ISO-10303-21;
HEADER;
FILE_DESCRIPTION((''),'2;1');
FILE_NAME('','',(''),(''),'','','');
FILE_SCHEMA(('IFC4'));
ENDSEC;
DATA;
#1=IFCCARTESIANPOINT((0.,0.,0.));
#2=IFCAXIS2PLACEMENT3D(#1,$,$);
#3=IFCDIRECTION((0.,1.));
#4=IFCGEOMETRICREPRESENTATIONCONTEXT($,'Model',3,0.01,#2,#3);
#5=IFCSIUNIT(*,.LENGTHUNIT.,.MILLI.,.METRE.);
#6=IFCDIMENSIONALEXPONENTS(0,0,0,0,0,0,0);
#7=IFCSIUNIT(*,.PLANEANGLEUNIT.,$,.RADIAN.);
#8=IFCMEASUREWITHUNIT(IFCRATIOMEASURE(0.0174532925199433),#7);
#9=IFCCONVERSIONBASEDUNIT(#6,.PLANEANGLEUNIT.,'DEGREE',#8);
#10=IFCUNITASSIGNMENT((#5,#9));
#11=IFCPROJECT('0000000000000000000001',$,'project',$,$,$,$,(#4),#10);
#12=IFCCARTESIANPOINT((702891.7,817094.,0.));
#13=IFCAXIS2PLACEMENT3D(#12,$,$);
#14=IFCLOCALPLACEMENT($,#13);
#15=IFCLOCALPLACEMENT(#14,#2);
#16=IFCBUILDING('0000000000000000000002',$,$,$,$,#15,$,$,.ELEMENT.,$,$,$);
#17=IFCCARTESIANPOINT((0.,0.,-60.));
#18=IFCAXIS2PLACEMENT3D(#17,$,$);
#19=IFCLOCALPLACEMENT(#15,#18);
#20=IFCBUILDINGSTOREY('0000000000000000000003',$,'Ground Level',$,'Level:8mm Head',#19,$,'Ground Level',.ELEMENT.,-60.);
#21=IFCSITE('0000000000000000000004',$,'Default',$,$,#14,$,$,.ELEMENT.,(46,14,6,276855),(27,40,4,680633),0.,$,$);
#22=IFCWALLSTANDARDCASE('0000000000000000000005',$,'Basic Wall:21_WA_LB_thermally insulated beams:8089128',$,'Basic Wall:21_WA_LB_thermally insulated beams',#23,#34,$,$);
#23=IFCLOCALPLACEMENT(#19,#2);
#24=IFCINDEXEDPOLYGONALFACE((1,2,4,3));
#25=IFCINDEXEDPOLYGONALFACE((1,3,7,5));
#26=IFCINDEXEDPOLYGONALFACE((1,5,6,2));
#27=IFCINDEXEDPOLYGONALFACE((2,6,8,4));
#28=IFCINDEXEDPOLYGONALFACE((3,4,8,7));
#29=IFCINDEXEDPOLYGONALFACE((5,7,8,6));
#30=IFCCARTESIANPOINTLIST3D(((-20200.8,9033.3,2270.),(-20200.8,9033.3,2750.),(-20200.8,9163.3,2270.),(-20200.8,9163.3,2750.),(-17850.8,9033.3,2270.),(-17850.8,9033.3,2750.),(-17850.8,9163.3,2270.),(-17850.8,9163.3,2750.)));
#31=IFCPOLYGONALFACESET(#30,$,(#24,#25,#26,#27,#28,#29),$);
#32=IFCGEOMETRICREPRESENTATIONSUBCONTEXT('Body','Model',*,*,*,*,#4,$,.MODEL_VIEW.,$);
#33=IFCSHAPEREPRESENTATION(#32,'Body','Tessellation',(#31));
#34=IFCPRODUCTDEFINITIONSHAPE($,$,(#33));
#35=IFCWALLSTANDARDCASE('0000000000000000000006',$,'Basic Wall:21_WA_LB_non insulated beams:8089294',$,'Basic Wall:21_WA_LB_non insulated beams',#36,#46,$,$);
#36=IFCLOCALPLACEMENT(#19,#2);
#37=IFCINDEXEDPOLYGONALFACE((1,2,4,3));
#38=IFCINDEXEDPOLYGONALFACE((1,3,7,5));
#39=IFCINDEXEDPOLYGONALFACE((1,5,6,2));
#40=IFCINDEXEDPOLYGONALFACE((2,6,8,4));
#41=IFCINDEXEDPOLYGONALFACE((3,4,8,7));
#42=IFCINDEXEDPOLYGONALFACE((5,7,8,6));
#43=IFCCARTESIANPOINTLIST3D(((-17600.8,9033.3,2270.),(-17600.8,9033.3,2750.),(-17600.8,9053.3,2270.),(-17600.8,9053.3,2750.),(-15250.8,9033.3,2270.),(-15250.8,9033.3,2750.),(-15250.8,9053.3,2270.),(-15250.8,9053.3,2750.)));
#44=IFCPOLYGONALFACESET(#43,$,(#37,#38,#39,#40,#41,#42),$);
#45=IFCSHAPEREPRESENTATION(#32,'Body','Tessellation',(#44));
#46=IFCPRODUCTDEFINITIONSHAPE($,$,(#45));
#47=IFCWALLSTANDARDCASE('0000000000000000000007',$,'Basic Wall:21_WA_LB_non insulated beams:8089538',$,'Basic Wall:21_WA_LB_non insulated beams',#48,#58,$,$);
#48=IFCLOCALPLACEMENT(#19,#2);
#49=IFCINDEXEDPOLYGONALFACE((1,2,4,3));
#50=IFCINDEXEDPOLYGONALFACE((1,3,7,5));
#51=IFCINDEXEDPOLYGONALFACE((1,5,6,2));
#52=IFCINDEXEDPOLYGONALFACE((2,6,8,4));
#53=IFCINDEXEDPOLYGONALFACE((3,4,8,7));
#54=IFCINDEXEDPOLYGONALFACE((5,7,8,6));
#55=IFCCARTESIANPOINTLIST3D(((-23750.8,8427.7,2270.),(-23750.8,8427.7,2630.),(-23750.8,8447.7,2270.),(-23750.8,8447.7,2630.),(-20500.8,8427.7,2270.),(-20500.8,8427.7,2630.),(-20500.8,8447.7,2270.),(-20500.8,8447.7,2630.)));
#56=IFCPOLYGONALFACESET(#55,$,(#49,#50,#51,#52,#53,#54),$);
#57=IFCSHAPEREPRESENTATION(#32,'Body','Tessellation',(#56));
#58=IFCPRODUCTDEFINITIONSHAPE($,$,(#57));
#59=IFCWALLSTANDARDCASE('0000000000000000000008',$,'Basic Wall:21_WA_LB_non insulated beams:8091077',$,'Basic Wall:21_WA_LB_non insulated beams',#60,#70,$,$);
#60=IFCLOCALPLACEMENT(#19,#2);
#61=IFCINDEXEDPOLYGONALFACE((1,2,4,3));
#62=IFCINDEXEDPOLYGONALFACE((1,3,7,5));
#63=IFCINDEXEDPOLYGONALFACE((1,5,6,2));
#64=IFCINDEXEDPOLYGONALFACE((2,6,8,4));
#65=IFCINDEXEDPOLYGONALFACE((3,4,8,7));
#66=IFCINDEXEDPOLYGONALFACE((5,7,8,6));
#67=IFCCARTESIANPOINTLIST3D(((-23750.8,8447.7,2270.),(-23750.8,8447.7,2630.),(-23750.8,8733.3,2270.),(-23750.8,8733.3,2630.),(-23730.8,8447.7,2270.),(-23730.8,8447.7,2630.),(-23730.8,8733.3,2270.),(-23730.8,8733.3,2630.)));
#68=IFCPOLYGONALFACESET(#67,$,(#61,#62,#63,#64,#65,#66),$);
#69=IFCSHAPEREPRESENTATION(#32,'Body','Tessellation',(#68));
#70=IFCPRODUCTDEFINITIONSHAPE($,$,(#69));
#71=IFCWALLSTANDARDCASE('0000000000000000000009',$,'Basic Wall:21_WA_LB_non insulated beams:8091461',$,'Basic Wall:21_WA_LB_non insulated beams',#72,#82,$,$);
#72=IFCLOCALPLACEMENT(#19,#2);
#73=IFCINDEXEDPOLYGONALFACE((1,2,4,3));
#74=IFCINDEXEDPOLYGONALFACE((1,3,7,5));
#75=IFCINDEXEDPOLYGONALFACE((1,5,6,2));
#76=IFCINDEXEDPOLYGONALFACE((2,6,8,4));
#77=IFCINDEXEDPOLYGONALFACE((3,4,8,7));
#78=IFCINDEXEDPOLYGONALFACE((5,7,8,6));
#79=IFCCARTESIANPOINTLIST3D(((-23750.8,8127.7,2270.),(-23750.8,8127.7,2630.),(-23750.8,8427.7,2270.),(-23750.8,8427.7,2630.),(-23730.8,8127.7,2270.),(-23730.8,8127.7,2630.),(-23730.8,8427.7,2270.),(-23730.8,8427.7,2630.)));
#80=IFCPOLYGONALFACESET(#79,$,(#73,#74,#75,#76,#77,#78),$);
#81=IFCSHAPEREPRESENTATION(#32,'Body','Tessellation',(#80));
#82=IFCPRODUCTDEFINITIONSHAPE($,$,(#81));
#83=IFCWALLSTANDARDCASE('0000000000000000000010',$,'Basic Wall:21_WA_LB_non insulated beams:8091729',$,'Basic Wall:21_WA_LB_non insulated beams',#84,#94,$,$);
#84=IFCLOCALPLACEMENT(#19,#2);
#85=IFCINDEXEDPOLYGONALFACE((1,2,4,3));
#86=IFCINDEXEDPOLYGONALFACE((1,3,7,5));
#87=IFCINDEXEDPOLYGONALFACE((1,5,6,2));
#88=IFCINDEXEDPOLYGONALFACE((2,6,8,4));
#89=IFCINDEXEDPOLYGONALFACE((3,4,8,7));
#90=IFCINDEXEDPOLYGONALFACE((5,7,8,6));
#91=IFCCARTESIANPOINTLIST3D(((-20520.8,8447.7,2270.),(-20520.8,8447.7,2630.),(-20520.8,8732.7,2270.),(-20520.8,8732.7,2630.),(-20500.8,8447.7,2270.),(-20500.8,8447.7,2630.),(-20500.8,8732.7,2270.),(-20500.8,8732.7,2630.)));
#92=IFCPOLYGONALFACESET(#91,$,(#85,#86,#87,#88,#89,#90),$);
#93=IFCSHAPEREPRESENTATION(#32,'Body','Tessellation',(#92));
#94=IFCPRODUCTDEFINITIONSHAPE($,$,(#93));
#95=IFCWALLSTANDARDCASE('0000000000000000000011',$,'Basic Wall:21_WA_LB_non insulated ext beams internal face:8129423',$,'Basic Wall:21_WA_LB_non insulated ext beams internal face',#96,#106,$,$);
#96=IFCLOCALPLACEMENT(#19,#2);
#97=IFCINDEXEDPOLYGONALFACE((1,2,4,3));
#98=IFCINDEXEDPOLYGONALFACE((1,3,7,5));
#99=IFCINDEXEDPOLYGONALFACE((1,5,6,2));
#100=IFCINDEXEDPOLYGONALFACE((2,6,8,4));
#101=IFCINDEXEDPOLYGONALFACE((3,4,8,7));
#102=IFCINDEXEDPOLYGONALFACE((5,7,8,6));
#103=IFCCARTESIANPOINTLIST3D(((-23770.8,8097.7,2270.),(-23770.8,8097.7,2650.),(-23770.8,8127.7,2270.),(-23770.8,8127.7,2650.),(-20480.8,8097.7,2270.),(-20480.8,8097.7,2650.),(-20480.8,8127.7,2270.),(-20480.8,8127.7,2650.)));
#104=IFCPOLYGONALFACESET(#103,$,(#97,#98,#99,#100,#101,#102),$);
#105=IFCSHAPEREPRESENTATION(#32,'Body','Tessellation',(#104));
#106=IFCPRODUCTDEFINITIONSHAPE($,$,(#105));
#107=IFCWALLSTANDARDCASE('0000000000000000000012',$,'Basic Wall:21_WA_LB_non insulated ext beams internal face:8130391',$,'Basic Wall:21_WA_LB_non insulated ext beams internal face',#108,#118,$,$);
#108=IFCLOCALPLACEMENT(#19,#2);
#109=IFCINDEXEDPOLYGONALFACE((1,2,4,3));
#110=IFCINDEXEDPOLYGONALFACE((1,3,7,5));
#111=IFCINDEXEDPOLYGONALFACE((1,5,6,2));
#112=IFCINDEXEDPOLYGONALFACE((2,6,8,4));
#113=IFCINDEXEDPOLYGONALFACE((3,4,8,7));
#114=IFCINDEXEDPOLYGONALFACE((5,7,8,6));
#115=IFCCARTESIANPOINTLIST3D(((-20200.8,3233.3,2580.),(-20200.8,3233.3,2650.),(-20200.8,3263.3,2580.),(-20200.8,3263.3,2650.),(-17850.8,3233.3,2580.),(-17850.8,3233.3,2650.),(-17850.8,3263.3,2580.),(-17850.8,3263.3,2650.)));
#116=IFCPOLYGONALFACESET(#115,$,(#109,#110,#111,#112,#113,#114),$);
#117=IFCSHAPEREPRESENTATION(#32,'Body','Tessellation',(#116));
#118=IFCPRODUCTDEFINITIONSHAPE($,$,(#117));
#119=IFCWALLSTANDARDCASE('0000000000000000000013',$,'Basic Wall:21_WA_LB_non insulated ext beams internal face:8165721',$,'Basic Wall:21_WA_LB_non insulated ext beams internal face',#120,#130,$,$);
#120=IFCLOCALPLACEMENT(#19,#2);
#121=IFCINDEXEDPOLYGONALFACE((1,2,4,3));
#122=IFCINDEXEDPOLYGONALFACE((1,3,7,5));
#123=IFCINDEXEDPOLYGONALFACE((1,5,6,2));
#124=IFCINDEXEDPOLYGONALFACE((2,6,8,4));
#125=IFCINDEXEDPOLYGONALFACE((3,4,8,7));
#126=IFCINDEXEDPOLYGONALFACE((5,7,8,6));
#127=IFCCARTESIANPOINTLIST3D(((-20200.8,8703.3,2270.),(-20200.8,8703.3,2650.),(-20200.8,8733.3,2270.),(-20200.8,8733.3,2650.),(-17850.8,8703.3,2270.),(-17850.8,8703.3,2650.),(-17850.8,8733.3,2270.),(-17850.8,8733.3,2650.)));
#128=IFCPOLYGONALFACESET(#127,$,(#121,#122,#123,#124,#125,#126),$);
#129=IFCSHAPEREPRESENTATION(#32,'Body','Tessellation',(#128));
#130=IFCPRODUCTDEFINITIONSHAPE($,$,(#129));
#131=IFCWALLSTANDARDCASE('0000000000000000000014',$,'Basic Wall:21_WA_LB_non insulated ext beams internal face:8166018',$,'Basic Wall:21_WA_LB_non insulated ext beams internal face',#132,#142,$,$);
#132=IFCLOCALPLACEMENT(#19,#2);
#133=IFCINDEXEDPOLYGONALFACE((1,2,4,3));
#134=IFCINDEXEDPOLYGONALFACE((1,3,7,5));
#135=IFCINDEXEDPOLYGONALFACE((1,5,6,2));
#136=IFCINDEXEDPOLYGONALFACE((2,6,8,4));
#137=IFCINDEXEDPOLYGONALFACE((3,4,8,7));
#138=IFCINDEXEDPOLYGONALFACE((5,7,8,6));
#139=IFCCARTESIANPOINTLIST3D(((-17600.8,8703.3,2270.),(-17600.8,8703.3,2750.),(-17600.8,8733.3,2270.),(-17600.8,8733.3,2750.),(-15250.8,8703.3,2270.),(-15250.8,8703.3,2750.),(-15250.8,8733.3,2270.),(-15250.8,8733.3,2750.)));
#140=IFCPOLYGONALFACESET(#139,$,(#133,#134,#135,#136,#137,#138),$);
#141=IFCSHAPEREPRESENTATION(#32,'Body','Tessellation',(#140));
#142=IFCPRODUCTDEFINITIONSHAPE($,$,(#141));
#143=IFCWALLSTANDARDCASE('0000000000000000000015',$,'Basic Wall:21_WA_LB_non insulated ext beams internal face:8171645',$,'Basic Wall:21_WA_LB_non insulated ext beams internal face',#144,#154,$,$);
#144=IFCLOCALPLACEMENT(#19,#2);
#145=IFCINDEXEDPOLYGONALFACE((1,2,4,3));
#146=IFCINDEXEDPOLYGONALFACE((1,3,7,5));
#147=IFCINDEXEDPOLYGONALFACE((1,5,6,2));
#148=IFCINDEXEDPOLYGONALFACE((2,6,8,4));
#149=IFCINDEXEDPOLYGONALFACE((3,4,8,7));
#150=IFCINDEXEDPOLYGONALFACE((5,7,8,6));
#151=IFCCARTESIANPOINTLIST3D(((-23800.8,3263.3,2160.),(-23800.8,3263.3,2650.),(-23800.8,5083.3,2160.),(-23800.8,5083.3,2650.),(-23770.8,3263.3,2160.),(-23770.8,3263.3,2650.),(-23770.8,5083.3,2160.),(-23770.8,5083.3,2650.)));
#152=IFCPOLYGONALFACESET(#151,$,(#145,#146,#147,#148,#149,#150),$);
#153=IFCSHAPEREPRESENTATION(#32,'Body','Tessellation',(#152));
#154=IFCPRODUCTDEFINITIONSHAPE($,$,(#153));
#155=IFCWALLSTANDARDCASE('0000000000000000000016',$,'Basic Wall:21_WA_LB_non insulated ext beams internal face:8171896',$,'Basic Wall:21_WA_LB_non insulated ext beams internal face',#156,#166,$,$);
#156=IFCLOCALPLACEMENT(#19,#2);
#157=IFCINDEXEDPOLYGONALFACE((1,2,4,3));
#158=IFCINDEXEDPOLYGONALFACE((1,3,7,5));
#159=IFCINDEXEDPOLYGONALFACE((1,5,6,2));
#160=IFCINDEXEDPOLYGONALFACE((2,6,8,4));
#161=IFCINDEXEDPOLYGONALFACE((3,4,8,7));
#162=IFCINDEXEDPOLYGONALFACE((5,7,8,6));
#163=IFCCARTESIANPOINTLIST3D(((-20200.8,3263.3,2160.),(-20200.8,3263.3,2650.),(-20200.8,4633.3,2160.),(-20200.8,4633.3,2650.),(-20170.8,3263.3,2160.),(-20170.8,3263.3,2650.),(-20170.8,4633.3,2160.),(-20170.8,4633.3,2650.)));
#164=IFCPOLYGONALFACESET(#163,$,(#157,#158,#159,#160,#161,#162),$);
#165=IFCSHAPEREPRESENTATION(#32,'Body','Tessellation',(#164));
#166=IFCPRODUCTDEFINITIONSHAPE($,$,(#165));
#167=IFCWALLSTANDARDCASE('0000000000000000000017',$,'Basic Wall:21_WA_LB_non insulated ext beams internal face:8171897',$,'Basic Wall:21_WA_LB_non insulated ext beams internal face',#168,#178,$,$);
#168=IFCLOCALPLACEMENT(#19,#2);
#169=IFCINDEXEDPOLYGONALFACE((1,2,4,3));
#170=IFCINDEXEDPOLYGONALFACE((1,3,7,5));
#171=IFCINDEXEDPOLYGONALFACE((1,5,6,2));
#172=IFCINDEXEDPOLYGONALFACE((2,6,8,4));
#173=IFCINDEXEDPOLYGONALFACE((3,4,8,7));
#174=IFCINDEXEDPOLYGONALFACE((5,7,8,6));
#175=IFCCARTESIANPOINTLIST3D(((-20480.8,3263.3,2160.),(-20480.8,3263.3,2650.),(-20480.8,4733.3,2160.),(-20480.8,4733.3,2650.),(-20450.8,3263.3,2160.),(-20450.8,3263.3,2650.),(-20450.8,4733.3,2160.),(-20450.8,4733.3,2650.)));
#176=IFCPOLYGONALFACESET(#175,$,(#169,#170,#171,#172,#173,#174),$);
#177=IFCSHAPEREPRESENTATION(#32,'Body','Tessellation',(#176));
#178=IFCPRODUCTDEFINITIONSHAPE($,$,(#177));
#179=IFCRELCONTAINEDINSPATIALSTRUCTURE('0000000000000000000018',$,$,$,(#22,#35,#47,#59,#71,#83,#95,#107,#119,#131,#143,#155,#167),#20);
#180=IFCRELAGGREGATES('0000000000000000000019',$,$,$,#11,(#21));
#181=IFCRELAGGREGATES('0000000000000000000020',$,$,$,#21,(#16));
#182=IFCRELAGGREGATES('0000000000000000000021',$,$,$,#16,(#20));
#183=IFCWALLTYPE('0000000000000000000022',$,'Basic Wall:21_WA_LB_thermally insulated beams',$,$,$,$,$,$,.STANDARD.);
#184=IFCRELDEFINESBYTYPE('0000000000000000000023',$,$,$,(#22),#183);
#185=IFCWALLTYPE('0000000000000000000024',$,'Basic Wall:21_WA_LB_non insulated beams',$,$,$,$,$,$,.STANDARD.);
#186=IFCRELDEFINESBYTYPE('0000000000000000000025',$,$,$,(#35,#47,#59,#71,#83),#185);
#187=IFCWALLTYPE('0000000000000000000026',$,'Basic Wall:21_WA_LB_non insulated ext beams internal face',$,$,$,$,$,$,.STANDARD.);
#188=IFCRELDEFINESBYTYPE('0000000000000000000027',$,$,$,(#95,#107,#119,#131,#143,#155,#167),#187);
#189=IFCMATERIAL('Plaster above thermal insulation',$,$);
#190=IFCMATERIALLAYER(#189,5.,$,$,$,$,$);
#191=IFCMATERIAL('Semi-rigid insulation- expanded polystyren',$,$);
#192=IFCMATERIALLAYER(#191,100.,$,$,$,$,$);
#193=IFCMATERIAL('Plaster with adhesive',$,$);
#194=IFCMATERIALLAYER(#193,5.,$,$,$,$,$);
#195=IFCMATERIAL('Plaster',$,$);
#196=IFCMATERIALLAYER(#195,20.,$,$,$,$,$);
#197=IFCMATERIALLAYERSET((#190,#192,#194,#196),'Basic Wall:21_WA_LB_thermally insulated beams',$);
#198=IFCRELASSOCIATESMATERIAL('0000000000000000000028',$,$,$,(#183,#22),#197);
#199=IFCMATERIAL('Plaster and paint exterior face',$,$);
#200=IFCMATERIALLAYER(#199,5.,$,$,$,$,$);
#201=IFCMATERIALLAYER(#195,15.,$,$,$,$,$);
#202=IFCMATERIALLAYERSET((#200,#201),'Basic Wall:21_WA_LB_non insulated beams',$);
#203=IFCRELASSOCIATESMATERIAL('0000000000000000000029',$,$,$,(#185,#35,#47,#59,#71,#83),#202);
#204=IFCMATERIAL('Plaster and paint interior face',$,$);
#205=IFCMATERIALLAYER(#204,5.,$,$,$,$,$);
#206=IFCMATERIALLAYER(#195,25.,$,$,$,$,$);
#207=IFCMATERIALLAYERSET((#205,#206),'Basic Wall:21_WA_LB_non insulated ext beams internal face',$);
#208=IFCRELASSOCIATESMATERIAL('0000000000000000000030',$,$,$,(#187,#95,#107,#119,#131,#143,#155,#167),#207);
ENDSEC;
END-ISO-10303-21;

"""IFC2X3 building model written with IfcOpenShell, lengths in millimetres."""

from ifc_helpers import new_model, entity, si_unit, converted_unit, direction, frame, frame_2d, origin, place, context, subcontext, project, spatial, rectangle, extrude, material, layer, layer_set, layer_usage, type_object, element, save


model = new_model("IFC2X3")

# Units and contexts
model_context = context("Model", 3, precision=0.01, world=origin(), true_north=direction((0.0, 1.0)))
body_context = subcontext(model_context, "Body", "Model", "MODEL_VIEW")
ifc_project = project(units=[si_unit("LENGTHUNIT", "METRE", prefix="MILLI"), converted_unit("PLANEANGLEUNIT", "DEGREE", entity("IfcRatioMeasure", 0.0174532925199433), si_unit("PLANEANGLEUNIT", "RADIAN"), dimensions=[0, 0, 0, 0, 0, 0, 0])], contexts=[model_context])

# Site, building, storey
site_placement = place(None, frame((702891.7, 817094.0, 0.0)))
site = spatial("IfcSite", under=ifc_project, at=site_placement, Name="Default", CompositionType="ELEMENT", RefLatitude=(46, 14, 6, 276855), RefLongitude=(27, 40, 4, 680633), RefElevation=0.0)
building_placement = place(site_placement, origin())
building = spatial("IfcBuilding", under=site, at=building_placement, CompositionType="ELEMENT")
storey_placement = place(building_placement, frame((0.0, 0.0, -60.0)))
storey = spatial("IfcBuildingStorey", under=building, at=storey_placement, Name="Ground Level", ObjectType="Level:8mm Head", LongName="Ground Level", CompositionType="ELEMENT", Elevation=-60.0)

# Walls
ifc_material_1 = material(Name="Plaster above thermal insulation")
ifc_layer_1 = layer(ifc_material_1, 5.0)
ifc_material_2 = material(Name="Semi-rigid insulation- expanded polystyren")
ifc_layer_2 = layer(ifc_material_2, 100.0)
ifc_material_3 = material(Name="Plaster with adhesive")
ifc_layer_3 = layer(ifc_material_3, 5.0)
ifc_material_4 = material(Name="Plaster")
ifc_layer_4 = layer(ifc_material_4, 20.0)
ifc_layer_set_1 = layer_set([ifc_layer_1, ifc_layer_2, ifc_layer_3, ifc_layer_4], Name="Basic Wall:21_WA_LB_thermally insulated beams")
ifc_layer_usage_1 = layer_usage(ifc_layer_set_1, "AXIS2", "NEGATIVE", 65.0)
wall_type_1 = type_object("IfcWallType", Name="Basic Wall:21_WA_LB_thermally insulated beams", PredefinedType="STANDARD", material=ifc_layer_set_1)
wall_1_placement = place(storey_placement, frame((-20200.8, 9098.3, 2270.0)))
element("IfcWallStandardCase", 1, at=wall_1_placement, inside=storey, type_object=wall_type_1, material=ifc_layer_usage_1, Name="Basic Wall:21_WA_LB_thermally insulated beams:8089128", ObjectType="Basic Wall:21_WA_LB_thermally insulated beams", context=body_context, shape_type="SweptSolid", body=[
    extrude(rectangle(XDim=2350.0, YDim=130.0, at=frame_2d((1175.0, 0.0), x_axis=(-1.0, 0.0))), origin(), (0.0, 0.0, 1.0), 480.0),
])
ifc_material_5 = material(Name="Plaster and paint exterior face")
ifc_layer_5 = layer(ifc_material_5, 5.0)
ifc_layer_6 = layer(ifc_material_4, 15.0)
ifc_layer_set_2 = layer_set([ifc_layer_5, ifc_layer_6], Name="Basic Wall:21_WA_LB_non insulated beams")
ifc_layer_usage_2 = layer_usage(ifc_layer_set_2, "AXIS2", "NEGATIVE", 10.0)
wall_type_2 = type_object("IfcWallType", Name="Basic Wall:21_WA_LB_non insulated beams", PredefinedType="STANDARD", material=ifc_layer_set_2)
wall_2_placement = place(storey_placement, frame((-17600.8, 9043.3, 2270.0)))
element("IfcWallStandardCase", 2, at=wall_2_placement, inside=storey, type_object=wall_type_2, material=ifc_layer_usage_2, Name="Basic Wall:21_WA_LB_non insulated beams:8089294", ObjectType="Basic Wall:21_WA_LB_non insulated beams", context=body_context, shape_type="SweptSolid", body=[
    extrude(rectangle(XDim=2350.0, YDim=20.0, at=frame_2d((1175.0, 0.0), x_axis=(-1.0, 0.0))), origin(), (0.0, 0.0, 1.0), 480.0),
])
ifc_layer_usage_3 = layer_usage(ifc_layer_set_2, "AXIS2", "NEGATIVE", 10.0)
wall_3_placement = place(storey_placement, frame((-23750.8, 8437.7, 2270.0)))
element("IfcWallStandardCase", 3, at=wall_3_placement, inside=storey, type_object=wall_type_2, material=ifc_layer_usage_3, Name="Basic Wall:21_WA_LB_non insulated beams:8089538", ObjectType="Basic Wall:21_WA_LB_non insulated beams", context=body_context, shape_type="SweptSolid", body=[
    extrude(rectangle(XDim=3250.0, YDim=20.0, at=frame_2d((1625.0, 0.0), x_axis=(-1.0, 0.0))), origin(), (0.0, 0.0, 1.0), 360.0),
])
ifc_layer_usage_4 = layer_usage(ifc_layer_set_2, "AXIS2", "NEGATIVE", 10.0)
wall_4_placement = place(storey_placement, frame((-23740.8, 8733.3, 2270.0), z_axis=(0.0, 0.0, 1.0), x_axis=(0.0, -1.0, 0.0)))
element("IfcWallStandardCase", 4, at=wall_4_placement, inside=storey, type_object=wall_type_2, material=ifc_layer_usage_4, Name="Basic Wall:21_WA_LB_non insulated beams:8091077", ObjectType="Basic Wall:21_WA_LB_non insulated beams", context=body_context, shape_type="SweptSolid", body=[
    extrude(rectangle(XDim=285.6, YDim=20.0, at=frame_2d((142.8, 0.0), x_axis=(-1.0, 0.0))), origin(), (0.0, 0.0, 1.0), 360.0),
])
ifc_layer_usage_5 = layer_usage(ifc_layer_set_2, "AXIS2", "POSITIVE", -10.0)
wall_5_placement = place(storey_placement, frame((-23740.8, 8127.7, 2270.0), z_axis=(0.0, 0.0, 1.0), x_axis=(0.0, 1.0, 0.0)))
element("IfcWallStandardCase", 5, at=wall_5_placement, inside=storey, type_object=wall_type_2, material=ifc_layer_usage_5, Name="Basic Wall:21_WA_LB_non insulated beams:8091461", ObjectType="Basic Wall:21_WA_LB_non insulated beams", context=body_context, shape_type="SweptSolid", body=[
    extrude(rectangle(XDim=300.0, YDim=20.0, at=frame_2d((150.0, 0.0), x_axis=(-1.0, 0.0))), origin(), (0.0, 0.0, 1.0), 360.0),
])
ifc_layer_usage_6 = layer_usage(ifc_layer_set_2, "AXIS2", "POSITIVE", -10.0)
wall_6_placement = place(storey_placement, frame((-20510.8, 8732.7, 2270.0), z_axis=(0.0, 0.0, 1.0), x_axis=(0.0, -1.0, 0.0)))
element("IfcWallStandardCase", 6, at=wall_6_placement, inside=storey, type_object=wall_type_2, material=ifc_layer_usage_6, Name="Basic Wall:21_WA_LB_non insulated beams:8091729", ObjectType="Basic Wall:21_WA_LB_non insulated beams", context=body_context, shape_type="SweptSolid", body=[
    extrude(rectangle(XDim=285.0, YDim=20.0, at=frame_2d((142.5, 0.0), x_axis=(-1.0, 0.0))), origin(), (0.0, 0.0, 1.0), 360.0),
])
ifc_material_6 = material(Name="Plaster and paint interior face")
ifc_layer_7 = layer(ifc_material_6, 5.0)
ifc_layer_8 = layer(ifc_material_4, 25.0)
ifc_layer_set_3 = layer_set([ifc_layer_7, ifc_layer_8], Name="Basic Wall:21_WA_LB_non insulated ext beams internal face")
ifc_layer_usage_7 = layer_usage(ifc_layer_set_3, "AXIS2", "POSITIVE", -15.0)
wall_type_3 = type_object("IfcWallType", Name="Basic Wall:21_WA_LB_non insulated ext beams internal face", PredefinedType="STANDARD", material=ifc_layer_set_3)
wall_7_placement = place(storey_placement, frame((-23770.8, 8112.7, 2270.0)))
element("IfcWallStandardCase", 7, at=wall_7_placement, inside=storey, type_object=wall_type_3, material=ifc_layer_usage_7, Name="Basic Wall:21_WA_LB_non insulated ext beams internal face:8129423", ObjectType="Basic Wall:21_WA_LB_non insulated ext beams internal face", context=body_context, shape_type="SweptSolid", body=[
    extrude(rectangle(XDim=3290.0, YDim=30.0, at=frame_2d((1645.0, 0.0), x_axis=(-1.0, 0.0))), origin(), (0.0, 0.0, 1.0), 380.0),
])
ifc_layer_usage_8 = layer_usage(ifc_layer_set_3, "AXIS2", "NEGATIVE", 15.0)
wall_8_placement = place(storey_placement, frame((-20200.8, 3248.3, 2580.0)))
element("IfcWallStandardCase", 8, at=wall_8_placement, inside=storey, type_object=wall_type_3, material=ifc_layer_usage_8, Name="Basic Wall:21_WA_LB_non insulated ext beams internal face:8130391", ObjectType="Basic Wall:21_WA_LB_non insulated ext beams internal face", context=body_context, shape_type="SweptSolid", body=[
    extrude(rectangle(XDim=2350.0, YDim=30.0, at=frame_2d((1175.0, 0.0), x_axis=(-1.0, 0.0))), origin(), (0.0, 0.0, 1.0), 70.0),
])
ifc_layer_usage_9 = layer_usage(ifc_layer_set_3, "AXIS2", "POSITIVE", -15.0)
wall_9_placement = place(storey_placement, frame((-20200.8, 8718.3, 2270.0)))
element("IfcWallStandardCase", 9, at=wall_9_placement, inside=storey, type_object=wall_type_3, material=ifc_layer_usage_9, Name="Basic Wall:21_WA_LB_non insulated ext beams internal face:8165721", ObjectType="Basic Wall:21_WA_LB_non insulated ext beams internal face", context=body_context, shape_type="SweptSolid", body=[
    extrude(rectangle(XDim=2350.0, YDim=30.0, at=frame_2d((1175.0, 0.0), x_axis=(-1.0, 0.0))), origin(), (0.0, 0.0, 1.0), 380.0),
])
ifc_layer_usage_10 = layer_usage(ifc_layer_set_3, "AXIS2", "POSITIVE", -15.0)
wall_10_placement = place(storey_placement, frame((-17600.8, 8718.3, 2270.0)))
element("IfcWallStandardCase", 10, at=wall_10_placement, inside=storey, type_object=wall_type_3, material=ifc_layer_usage_10, Name="Basic Wall:21_WA_LB_non insulated ext beams internal face:8166018", ObjectType="Basic Wall:21_WA_LB_non insulated ext beams internal face", context=body_context, shape_type="SweptSolid", body=[
    extrude(rectangle(XDim=2350.0, YDim=30.0, at=frame_2d((1175.0, 0.0), x_axis=(-1.0, 0.0))), origin(), (0.0, 0.0, 1.0), 480.0),
])
ifc_layer_usage_11 = layer_usage(ifc_layer_set_3, "AXIS2", "NEGATIVE", 15.0)
wall_11_placement = place(storey_placement, frame((-23785.8, 5083.3, 2160.0), z_axis=(0.0, 0.0, 1.0), x_axis=(0.0, -1.0, 0.0)))
element("IfcWallStandardCase", 11, at=wall_11_placement, inside=storey, type_object=wall_type_3, material=ifc_layer_usage_11, Name="Basic Wall:21_WA_LB_non insulated ext beams internal face:8171645", ObjectType="Basic Wall:21_WA_LB_non insulated ext beams internal face", context=body_context, shape_type="SweptSolid", body=[
    extrude(rectangle(XDim=1820.0, YDim=30.0, at=frame_2d((910.0, 0.0), x_axis=(-1.0, 0.0))), origin(), (0.0, 0.0, 1.0), 490.0),
])
ifc_layer_usage_12 = layer_usage(ifc_layer_set_3, "AXIS2", "NEGATIVE", 15.0)
wall_12_placement = place(storey_placement, frame((-20185.8, 4633.3, 2160.0), z_axis=(0.0, 0.0, 1.0), x_axis=(0.0, -1.0, 0.0)))
element("IfcWallStandardCase", 12, at=wall_12_placement, inside=storey, type_object=wall_type_3, material=ifc_layer_usage_12, Name="Basic Wall:21_WA_LB_non insulated ext beams internal face:8171896", ObjectType="Basic Wall:21_WA_LB_non insulated ext beams internal face", context=body_context, shape_type="SweptSolid", body=[
    extrude(rectangle(XDim=1370.0, YDim=30.0, at=frame_2d((685.0, 0.0), x_axis=(-1.0, 0.0))), origin(), (0.0, 0.0, 1.0), 490.0),
])
ifc_layer_usage_13 = layer_usage(ifc_layer_set_3, "AXIS2", "POSITIVE", -15.0)
wall_13_placement = place(storey_placement, frame((-20465.8, 4733.3, 2160.0), z_axis=(0.0, 0.0, 1.0), x_axis=(0.0, -1.0, 0.0)))
element("IfcWallStandardCase", 13, at=wall_13_placement, inside=storey, type_object=wall_type_3, material=ifc_layer_usage_13, Name="Basic Wall:21_WA_LB_non insulated ext beams internal face:8171897", ObjectType="Basic Wall:21_WA_LB_non insulated ext beams internal face", context=body_context, shape_type="SweptSolid", body=[
    extrude(rectangle(XDim=1470.0, YDim=30.0, at=frame_2d((735.0, 0.0), x_axis=(-1.0, 0.0))), origin(), (0.0, 0.0, 1.0), 490.0),
])

save(model, "model.ifc")
